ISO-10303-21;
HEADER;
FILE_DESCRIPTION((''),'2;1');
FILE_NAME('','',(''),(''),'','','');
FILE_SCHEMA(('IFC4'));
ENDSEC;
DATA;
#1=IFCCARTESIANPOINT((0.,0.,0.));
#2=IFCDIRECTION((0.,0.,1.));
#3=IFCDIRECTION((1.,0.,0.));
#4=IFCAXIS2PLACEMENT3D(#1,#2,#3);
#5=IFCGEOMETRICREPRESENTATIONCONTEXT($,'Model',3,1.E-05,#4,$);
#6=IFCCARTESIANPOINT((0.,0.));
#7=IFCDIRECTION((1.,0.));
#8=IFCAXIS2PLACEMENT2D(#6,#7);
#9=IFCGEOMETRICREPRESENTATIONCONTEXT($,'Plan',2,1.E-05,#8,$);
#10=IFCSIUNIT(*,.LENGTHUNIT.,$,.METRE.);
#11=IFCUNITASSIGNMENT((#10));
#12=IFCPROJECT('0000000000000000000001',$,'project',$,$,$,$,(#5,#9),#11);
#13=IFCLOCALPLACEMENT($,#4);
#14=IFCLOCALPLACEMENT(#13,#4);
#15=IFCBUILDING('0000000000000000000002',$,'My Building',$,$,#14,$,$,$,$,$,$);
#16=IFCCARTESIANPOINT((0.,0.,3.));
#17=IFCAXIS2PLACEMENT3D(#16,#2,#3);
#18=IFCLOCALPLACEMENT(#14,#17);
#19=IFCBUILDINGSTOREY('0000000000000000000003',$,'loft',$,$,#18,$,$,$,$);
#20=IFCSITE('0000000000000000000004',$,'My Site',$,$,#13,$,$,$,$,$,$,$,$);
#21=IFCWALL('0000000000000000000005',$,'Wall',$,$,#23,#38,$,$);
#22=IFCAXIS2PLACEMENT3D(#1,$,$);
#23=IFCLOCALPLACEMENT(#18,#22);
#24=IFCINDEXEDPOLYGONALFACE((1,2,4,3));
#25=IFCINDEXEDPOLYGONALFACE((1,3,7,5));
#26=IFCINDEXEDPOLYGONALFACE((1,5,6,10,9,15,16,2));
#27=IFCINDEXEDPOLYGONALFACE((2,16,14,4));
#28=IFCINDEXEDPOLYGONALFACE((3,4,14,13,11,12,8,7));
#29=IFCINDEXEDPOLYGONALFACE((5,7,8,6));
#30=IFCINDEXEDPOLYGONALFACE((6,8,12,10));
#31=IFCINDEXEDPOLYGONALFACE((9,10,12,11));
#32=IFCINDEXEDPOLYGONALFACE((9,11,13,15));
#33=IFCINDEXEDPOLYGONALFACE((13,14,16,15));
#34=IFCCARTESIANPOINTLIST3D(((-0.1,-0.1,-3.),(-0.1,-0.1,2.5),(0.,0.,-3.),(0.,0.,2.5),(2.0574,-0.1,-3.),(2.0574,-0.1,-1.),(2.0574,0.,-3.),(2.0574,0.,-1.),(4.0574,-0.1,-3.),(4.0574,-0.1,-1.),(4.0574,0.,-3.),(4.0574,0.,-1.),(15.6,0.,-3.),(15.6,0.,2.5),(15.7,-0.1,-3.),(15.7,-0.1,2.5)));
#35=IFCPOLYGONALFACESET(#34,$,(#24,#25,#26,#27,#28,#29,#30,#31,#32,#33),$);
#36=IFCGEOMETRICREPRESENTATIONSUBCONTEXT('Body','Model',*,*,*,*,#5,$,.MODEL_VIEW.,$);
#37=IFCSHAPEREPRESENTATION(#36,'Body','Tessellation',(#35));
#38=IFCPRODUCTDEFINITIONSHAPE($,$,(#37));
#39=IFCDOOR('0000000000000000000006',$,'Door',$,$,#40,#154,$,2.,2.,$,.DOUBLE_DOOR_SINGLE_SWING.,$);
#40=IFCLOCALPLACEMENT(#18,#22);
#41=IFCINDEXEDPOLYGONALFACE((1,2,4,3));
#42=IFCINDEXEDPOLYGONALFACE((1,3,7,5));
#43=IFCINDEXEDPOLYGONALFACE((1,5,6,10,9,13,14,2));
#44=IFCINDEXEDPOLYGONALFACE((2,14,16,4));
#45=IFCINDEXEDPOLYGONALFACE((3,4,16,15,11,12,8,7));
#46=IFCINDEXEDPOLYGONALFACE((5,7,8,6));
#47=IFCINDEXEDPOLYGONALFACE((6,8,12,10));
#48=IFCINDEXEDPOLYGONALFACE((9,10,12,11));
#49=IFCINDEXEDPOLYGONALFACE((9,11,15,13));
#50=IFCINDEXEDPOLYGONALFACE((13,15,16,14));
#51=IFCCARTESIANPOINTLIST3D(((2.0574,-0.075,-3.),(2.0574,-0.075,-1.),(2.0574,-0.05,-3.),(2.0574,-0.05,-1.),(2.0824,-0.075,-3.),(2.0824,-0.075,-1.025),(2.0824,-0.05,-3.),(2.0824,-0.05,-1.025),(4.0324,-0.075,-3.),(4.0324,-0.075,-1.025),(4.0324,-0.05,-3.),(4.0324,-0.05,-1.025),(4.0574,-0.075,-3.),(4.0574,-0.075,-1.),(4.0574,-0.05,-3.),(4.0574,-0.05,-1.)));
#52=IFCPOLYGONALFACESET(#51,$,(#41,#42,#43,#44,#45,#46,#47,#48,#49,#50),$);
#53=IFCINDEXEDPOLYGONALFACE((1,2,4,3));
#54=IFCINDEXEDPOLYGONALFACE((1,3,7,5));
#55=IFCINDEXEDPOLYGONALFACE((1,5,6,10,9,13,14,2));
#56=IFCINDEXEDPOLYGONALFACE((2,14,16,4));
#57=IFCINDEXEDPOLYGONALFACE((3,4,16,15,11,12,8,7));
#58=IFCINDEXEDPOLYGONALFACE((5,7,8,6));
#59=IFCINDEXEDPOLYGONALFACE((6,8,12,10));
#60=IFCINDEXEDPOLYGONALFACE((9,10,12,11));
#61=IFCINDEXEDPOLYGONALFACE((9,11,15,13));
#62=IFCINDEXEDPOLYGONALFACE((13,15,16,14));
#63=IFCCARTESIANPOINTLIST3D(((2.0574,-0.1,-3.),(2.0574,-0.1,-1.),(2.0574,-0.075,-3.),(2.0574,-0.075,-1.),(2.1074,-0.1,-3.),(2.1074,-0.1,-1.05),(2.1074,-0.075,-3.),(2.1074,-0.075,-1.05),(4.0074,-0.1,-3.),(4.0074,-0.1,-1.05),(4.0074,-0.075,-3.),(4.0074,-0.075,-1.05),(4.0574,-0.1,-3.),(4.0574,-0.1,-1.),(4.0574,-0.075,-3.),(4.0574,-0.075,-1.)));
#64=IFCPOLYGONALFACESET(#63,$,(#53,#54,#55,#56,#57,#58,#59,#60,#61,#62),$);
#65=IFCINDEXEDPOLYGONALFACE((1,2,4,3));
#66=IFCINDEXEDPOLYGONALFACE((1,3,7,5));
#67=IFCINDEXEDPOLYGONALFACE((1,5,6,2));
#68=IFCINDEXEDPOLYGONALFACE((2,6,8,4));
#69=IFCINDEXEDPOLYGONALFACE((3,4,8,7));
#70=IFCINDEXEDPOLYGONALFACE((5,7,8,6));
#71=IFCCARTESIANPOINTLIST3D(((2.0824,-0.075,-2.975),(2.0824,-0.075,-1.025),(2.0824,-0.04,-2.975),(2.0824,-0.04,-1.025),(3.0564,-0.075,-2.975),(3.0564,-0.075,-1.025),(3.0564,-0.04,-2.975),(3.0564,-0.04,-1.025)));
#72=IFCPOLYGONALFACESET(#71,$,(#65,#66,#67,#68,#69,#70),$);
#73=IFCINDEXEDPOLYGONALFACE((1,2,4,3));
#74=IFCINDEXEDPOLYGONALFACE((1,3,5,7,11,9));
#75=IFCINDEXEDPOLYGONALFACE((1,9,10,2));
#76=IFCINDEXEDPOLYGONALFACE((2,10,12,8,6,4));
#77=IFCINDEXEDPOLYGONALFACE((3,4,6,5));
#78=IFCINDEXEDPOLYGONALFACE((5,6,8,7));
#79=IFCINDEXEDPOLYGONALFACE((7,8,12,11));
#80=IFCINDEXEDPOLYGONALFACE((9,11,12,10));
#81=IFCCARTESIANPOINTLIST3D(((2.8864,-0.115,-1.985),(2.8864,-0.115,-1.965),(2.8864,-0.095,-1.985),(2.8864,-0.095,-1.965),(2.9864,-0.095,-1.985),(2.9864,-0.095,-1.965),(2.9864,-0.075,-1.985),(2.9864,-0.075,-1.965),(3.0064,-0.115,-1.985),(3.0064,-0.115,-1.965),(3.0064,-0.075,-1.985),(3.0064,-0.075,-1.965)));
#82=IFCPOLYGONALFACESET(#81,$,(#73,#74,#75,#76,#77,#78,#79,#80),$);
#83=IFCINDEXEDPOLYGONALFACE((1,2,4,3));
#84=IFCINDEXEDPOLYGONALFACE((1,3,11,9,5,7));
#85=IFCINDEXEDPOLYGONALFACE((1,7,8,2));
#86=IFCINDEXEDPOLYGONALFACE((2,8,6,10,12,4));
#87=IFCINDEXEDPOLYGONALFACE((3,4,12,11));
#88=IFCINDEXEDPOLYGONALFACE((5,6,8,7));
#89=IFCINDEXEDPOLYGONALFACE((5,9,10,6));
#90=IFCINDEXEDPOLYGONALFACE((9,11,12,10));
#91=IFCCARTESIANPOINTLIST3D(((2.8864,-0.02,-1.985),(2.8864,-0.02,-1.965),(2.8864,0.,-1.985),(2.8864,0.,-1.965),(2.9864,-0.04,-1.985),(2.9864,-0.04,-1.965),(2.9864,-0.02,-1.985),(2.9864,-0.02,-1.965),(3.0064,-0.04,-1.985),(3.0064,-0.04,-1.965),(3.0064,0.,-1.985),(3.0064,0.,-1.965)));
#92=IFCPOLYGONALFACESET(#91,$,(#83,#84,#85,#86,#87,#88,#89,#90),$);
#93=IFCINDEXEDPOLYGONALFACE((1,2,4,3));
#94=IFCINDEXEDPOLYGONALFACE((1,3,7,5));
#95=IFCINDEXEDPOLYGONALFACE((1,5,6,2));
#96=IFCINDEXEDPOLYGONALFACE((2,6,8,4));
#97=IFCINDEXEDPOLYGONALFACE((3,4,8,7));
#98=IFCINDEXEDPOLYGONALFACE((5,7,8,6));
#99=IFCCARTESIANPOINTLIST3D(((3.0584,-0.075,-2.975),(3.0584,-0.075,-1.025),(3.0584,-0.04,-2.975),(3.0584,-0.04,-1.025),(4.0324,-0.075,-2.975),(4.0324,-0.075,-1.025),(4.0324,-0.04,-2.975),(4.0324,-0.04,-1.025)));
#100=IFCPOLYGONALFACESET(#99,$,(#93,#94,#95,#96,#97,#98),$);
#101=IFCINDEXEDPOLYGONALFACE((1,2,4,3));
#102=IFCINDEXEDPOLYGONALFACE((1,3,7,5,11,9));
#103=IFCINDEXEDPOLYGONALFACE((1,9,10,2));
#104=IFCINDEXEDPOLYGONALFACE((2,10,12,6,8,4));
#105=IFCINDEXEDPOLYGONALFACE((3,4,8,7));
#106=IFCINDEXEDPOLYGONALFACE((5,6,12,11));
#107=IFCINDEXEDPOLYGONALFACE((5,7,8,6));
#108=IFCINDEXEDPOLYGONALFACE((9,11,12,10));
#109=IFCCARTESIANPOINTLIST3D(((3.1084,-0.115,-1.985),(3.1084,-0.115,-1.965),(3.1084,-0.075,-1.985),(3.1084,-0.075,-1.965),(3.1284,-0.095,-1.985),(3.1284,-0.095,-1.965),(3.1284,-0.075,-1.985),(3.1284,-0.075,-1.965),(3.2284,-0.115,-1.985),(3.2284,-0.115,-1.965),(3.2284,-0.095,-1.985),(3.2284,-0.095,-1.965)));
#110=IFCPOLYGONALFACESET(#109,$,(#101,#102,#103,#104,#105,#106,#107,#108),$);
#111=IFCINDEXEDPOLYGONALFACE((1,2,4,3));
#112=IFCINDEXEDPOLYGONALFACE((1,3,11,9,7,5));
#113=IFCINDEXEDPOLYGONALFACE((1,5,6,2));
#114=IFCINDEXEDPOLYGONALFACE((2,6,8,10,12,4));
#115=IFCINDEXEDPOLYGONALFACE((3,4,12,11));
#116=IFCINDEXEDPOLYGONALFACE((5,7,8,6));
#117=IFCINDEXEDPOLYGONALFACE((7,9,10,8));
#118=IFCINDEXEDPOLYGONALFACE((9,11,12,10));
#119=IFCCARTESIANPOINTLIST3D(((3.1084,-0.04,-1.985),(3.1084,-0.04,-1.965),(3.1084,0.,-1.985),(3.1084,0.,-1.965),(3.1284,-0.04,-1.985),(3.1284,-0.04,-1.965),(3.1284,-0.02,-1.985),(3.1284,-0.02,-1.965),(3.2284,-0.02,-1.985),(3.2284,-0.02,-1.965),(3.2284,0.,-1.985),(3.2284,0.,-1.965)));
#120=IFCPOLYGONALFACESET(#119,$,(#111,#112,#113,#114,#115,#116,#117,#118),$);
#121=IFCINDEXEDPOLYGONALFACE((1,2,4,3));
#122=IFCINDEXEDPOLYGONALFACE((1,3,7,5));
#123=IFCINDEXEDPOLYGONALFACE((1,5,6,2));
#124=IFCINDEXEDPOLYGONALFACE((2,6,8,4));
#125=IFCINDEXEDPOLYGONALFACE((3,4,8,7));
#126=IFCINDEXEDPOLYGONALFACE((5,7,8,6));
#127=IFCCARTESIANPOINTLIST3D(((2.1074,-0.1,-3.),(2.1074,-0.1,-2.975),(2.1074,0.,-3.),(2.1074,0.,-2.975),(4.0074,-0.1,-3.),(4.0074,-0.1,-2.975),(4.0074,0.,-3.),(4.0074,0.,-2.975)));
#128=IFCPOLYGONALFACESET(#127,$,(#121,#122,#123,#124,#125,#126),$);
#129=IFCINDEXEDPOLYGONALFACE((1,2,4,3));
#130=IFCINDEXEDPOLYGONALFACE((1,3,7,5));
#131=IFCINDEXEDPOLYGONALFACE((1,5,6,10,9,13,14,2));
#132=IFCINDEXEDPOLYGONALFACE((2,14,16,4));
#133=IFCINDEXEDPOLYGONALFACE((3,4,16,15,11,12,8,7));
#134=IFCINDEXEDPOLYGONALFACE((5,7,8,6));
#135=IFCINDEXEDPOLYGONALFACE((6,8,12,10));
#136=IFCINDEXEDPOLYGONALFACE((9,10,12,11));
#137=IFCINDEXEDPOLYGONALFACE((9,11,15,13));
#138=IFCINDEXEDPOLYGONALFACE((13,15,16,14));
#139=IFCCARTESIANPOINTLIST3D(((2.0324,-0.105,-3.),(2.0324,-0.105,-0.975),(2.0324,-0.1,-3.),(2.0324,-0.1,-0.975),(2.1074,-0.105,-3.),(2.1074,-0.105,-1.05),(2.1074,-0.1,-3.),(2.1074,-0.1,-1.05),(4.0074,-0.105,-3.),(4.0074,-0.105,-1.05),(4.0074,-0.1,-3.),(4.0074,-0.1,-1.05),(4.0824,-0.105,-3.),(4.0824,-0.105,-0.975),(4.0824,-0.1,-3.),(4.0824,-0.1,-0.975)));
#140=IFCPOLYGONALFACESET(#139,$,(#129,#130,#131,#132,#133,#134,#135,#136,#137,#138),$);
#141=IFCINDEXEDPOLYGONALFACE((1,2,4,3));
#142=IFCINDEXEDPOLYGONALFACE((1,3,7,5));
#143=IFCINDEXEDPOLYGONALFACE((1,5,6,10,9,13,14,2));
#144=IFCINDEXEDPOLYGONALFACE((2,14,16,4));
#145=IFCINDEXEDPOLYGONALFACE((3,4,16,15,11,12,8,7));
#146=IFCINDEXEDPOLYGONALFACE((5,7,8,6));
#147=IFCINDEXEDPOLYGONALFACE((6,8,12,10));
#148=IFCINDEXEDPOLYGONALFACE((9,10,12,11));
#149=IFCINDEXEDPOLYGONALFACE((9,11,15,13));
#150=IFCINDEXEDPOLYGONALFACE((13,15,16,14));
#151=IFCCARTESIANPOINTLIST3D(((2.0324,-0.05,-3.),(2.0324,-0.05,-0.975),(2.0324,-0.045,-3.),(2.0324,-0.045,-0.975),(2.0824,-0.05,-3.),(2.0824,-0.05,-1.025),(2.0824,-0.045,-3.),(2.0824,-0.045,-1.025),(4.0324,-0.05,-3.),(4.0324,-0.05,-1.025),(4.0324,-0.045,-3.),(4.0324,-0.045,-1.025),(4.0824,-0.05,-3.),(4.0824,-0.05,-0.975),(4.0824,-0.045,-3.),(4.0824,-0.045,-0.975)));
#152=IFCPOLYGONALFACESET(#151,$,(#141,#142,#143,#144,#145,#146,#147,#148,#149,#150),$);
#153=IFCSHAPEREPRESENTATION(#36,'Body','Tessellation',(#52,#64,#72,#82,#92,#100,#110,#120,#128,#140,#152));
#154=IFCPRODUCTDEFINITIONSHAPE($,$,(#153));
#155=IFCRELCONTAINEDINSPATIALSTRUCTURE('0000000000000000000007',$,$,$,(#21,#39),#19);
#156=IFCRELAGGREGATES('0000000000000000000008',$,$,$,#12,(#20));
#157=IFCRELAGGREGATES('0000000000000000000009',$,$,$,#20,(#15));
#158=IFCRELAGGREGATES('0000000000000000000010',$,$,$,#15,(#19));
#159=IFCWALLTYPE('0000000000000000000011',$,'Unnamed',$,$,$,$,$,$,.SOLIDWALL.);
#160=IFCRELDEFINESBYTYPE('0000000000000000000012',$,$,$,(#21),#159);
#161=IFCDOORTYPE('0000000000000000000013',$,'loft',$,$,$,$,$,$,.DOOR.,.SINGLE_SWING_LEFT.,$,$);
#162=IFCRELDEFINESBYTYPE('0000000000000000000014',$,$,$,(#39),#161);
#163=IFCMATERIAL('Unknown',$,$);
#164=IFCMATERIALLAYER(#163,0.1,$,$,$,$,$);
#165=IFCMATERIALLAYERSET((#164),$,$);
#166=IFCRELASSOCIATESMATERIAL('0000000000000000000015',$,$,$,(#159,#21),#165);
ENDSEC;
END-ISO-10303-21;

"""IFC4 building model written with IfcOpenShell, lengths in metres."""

from ifc_helpers import new_model, entity, si_unit, frame, origin_with_axes, origin_2d_with_axis, place, context, subcontext, project, spatial, line, indexed_curve, outline, extrude, shape, source, transform, mapped, material, layer, layer_set, layer_usage, type_object, type_shapes, element, fill, save


model = new_model("IFC4")

# Units and contexts
model_context = context("Model", 3, precision=1e-05, world=origin_with_axes())
plan_context = context("Plan", 2, precision=1e-05, world=origin_2d_with_axis())
body_context_1 = subcontext(model_context, "Body", "Model", "MODEL_VIEW")
body_context_2 = subcontext(plan_context, "Body", "Plan", "PLAN_VIEW")
ifc_project = project(units=[si_unit("LENGTHUNIT", "METRE")], contexts=[model_context, plan_context])

# Site, building, storey
site_placement = place(None, origin_with_axes())
site = spatial("IfcSite", under=ifc_project, at=site_placement, Name="My Site")
building_placement = place(site_placement, origin_with_axes())
building = spatial("IfcBuilding", under=site, at=building_placement, Name="My Building")
storey_placement = place(building_placement, frame((0.0, 0.0, 3.0), z_axis=(0.0, 0.0, 1.0), x_axis=(1.0, 0.0, 0.0)))
storey = spatial("IfcBuildingStorey", under=building, at=storey_placement, Name="loft")

# Shared definitions
ifc_material = material(Name="Unknown")

# Shared definitions
ifc_layer_1 = layer(ifc_material, 0.1)
ifc_layer_set_1 = layer_set([ifc_layer_1])
wall_type = type_object("IfcWallType", Name="Unnamed", PredefinedType="SOLIDWALL", material=ifc_layer_set_1)

# Wall, opening, door
ifc_layer_usage_1 = layer_usage(ifc_layer_set_1, "AXIS2", "POSITIVE", 0.0)
wall_1_placement = place(storey_placement, frame((15.6, 0.0, -3.0), z_axis=(0.0, 0.0, 1.0), x_axis=(-1.0, 0.0, 0.0)))
wall_1 = element("IfcWall", 1, at=wall_1_placement, inside=storey, type_object=wall_type, material=ifc_layer_usage_1, Name="Wall", context=body_context_1, shape_type="SweptSolid", body=[
    extrude(outline(indexed_curve([(0.0, 0.0), (-0.1, 0.1), (15.7, 0.1), (15.6, 0.0)], segments=[line(1, 2, 3, 4, 1)])), origin_with_axes(), (0.0, 0.0, 1.0), 5.5),
])
shared_shape_1 = source(origin_with_axes(), body_context_1, "Body", "SweptSolid", [
    extrude(outline(indexed_curve([(0.0, 0.0), (2.0, 0.0), (2.0, 2.0), (0.0, 2.0)], segments=[line(1, 2, 3, 4, 1)])), frame((0.0, -0.6, 0.0), z_axis=(0.0, -1.0, 0.0), x_axis=(1.0, 0.0, 0.0)), (0.0, 0.0, -1.0), 1.2),
])
opening_1_placement = place(wall_1_placement, frame((13.5426, 0.1, 0.0), z_axis=(0.0, 0.0, 1.0), x_axis=(-1.0, 0.0, 0.0)))
opening_1 = element("IfcOpeningElement", 2, at=opening_1_placement, cuts=wall_1, PredefinedType="OPENING", context=body_context_1, shape_type="MappedRepresentation", body=[
    mapped(shared_shape_1, transform((0.0, 0.0, 0.0), x_axis=(1.0, 0.0, 0.0), y_axis=(0.0, 1.0, 0.0), z_axis=(0.0, 0.0, 1.0), scale=1.0)),
])
door_type = type_object("IfcDoorType", Name="loft", OperationType="SINGLE_SWING_LEFT", PredefinedType="DOOR")
shared_shape_2 = source(origin_with_axes(), body_context_1, "Body", "SweptSolid", [
    extrude(outline(indexed_curve([(0.0, 0.0), (0.0, 2.0), (2.0, 2.0), (2.0, 0.0), (1.975, 0.0), (1.975, 1.975), (0.025, 1.975), (0.025, 0.0)], segments=[line(1, 2, 3, 4, 5, 6, 7, 8, 1)])), frame((0.0, 0.025, 0.0), z_axis=(0.0, -1.0, 0.0), x_axis=(1.0, 0.0, 0.0)), (0.0, 0.0, -1.0), 0.025),
    extrude(outline(indexed_curve([(0.0, 0.0), (0.0, 2.0), (2.0, 2.0), (2.0, 0.0), (1.95, 0.0), (1.95, 1.95), (0.05, 1.95), (0.05, 0.0)], segments=[line(1, 2, 3, 4, 5, 6, 7, 8, 1)])), frame((0.0, 0.0, 0.0), z_axis=(0.0, -1.0, 0.0), x_axis=(1.0, 0.0, 0.0)), (0.0, 0.0, -1.0), 0.025),
    extrude(outline(indexed_curve([(0.0, 0.0), (0.974, 0.0), (0.974, 0.035), (0.0, 0.035)], segments=[line(1, 2, 3, 4, 1)])), frame((0.025, 0.025, 0.025), z_axis=(0.0, 0.0, 1.0), x_axis=(1.0, 0.0, 0.0)), (0.0, 0.0, 1.0), 1.95),
    extrude(outline(indexed_curve([(0.0, 0.0), (0.0, -0.04), (-0.12, -0.04), (-0.12, -0.02), (-0.02, -0.02), (-0.02, 0.0)], segments=[line(1, 2, 3, 4, 5, 6, 1)])), frame((0.949, 0.025, 1.015), z_axis=(0.0, 0.0, 1.0), x_axis=(1.0, 0.0, 0.0)), (0.0, 0.0, 1.0), 0.02),
    extrude(outline(indexed_curve([(0.0, 0.0), (0.0, 0.04), (-0.12, 0.04), (-0.12, 0.02), (-0.02, 0.02), (-0.02, 0.0)], segments=[line(1, 2, 3, 4, 5, 6, 1)])), frame((0.949, 0.06, 1.015), z_axis=(0.0, 0.0, 1.0), x_axis=(1.0, 0.0, 0.0)), (0.0, 0.0, 1.0), 0.02),
    extrude(outline(indexed_curve([(0.0, 0.0), (-0.974, 0.0), (-0.974, 0.035), (0.0, 0.035)], segments=[line(1, 2, 3, 4, 1)])), frame((1.975, 0.025, 0.025), z_axis=(0.0, 0.0, 1.0), x_axis=(1.0, 0.0, 0.0)), (0.0, 0.0, 1.0), 1.95),
    extrude(outline(indexed_curve([(0.0, 0.0), (0.0, -0.04), (0.12, -0.04), (0.12, -0.02), (0.02, -0.02), (0.02, 0.0)], segments=[line(1, 2, 3, 4, 5, 6, 1)])), frame((1.051, 0.025, 1.015), z_axis=(0.0, 0.0, 1.0), x_axis=(1.0, 0.0, 0.0)), (0.0, 0.0, 1.0), 0.02),
    extrude(outline(indexed_curve([(0.0, 0.0), (0.0, 0.04), (0.12, 0.04), (0.12, 0.02), (0.02, 0.02), (0.02, 0.0)], segments=[line(1, 2, 3, 4, 5, 6, 1)])), frame((1.051, 0.06, 1.015), z_axis=(0.0, 0.0, 1.0), x_axis=(1.0, 0.0, 0.0)), (0.0, 0.0, 1.0), 0.02),
    extrude(outline(indexed_curve([(0.0, 0.0), (1.9, 0.0), (1.9, 0.1), (0.0, 0.1)], segments=[line(1, 2, 3, 4, 1)])), frame((0.05, 0.0, 0.0), z_axis=(0.0, 0.0, 1.0), x_axis=(1.0, 0.0, 0.0)), (0.0, 0.0, 1.0), 0.025),
    extrude(outline(indexed_curve([(0.0, 0.0), (0.0, 2.025), (2.05, 2.025), (2.05, 0.0), (1.975, 0.0), (1.975, 1.95), (0.075, 1.95), (0.075, 0.0)], segments=[line(1, 2, 3, 4, 5, 6, 7, 8, 1)])), frame((-0.025, -0.005, 0.0), z_axis=(0.0, -1.0, 0.0), x_axis=(1.0, 0.0, 0.0)), (0.0, 0.0, -1.0), 0.005),
    extrude(outline(indexed_curve([(0.0, 0.0), (0.0, 2.025), (2.05, 2.025), (2.05, 0.0), (2.0, 0.0), (2.0, 1.975), (0.05, 1.975), (0.05, 0.0)], segments=[line(1, 2, 3, 4, 5, 6, 7, 8, 1)])), frame((-0.025, 0.05, 0.0), z_axis=(0.0, -1.0, 0.0), x_axis=(1.0, 0.0, 0.0)), (0.0, 0.0, -1.0), 0.005),
])
shared_shape_3 = source(origin_with_axes(), body_context_2, "Body", "Curve2D", [
    entity("IfcIndexedPolyCurve", entity("IfcCartesianPointList2D", [[0.0, 0.0], [0.0, 0.05], [0.025, 0.05], [0.025, 0.025], [0.05, 0.025], [0.05, 0.0]]), [entity("IfcLineIndex", [1, 2, 3, 4, 5, 6, 1])]),
    entity("IfcIndexedPolyCurve", entity("IfcCartesianPointList2D", [[2.0, 0.0], [2.0, 0.05], [1.975, 0.05], [1.975, 0.025], [1.95, 0.025], [1.95, 0.0]]), [entity("IfcLineIndex", [1, 2, 3, 4, 5, 6, 1])]),
    entity("IfcTrimmedCurve", entity("IfcEllipse", entity("IfcAxis2Placement2D", entity("IfcCartesianPoint", [0.06, 0.05]), entity("IfcDirection", [1.0, 0.0])), 0.94, 0.975), [entity("IfcCartesianPoint", [1.0, 0.05])], [entity("IfcCartesianPoint", [0.06, 1.025])], True, "CARTESIAN"),
    entity("IfcIndexedPolyCurve", entity("IfcCartesianPointList2D", [[0.025, 0.05], [0.06, 0.05], [0.06, 1.025], [0.025, 1.025]]), [entity("IfcLineIndex", [1, 2, 3, 4, 1])]),
    entity("IfcTrimmedCurve", entity("IfcEllipse", entity("IfcAxis2Placement2D", entity("IfcCartesianPoint", [1.94, 0.05]), entity("IfcDirection", [1.0, 0.0])), 0.94, 0.975), [entity("IfcCartesianPoint", [1.94, 1.025])], [entity("IfcCartesianPoint", [1.0, 0.05])], True, "CARTESIAN"),
    entity("IfcIndexedPolyCurve", entity("IfcCartesianPointList2D", [[1.975, 0.05], [1.94, 0.05], [1.94, 1.025], [1.975, 1.025]]), [entity("IfcLineIndex", [1, 2, 3, 4, 1])]),
])
type_shapes(door_type, [shared_shape_2, shared_shape_3])
door_placement = place(opening_1_placement, origin_with_axes())
door = element("IfcDoor", 3, at=door_placement, inside=storey, type_object=door_type, Name="Door", OperationType="DOUBLE_DOOR_SINGLE_SWING", OverallHeight=2.0, OverallWidth=2.0, shapes=[
    shape(body_context_1, "Body", "MappedRepresentation", [mapped(shared_shape_2, transform((0.0, 0.0, 0.0), x_axis=(1.0, 0.0, 0.0), y_axis=(0.0, 1.0, 0.0), z_axis=(0.0, 0.0, 1.0), scale=1.0))]),
    shape(body_context_2, "Body", "MappedRepresentation", [mapped(shared_shape_3, transform((0.0, 0.0, 0.0), x_axis=(1.0, 0.0, 0.0), y_axis=(0.0, 1.0, 0.0), z_axis=(0.0, 0.0, 1.0), scale=1.0))]),
])
fill(opening_1, door)

save(model, "model.ifc")
